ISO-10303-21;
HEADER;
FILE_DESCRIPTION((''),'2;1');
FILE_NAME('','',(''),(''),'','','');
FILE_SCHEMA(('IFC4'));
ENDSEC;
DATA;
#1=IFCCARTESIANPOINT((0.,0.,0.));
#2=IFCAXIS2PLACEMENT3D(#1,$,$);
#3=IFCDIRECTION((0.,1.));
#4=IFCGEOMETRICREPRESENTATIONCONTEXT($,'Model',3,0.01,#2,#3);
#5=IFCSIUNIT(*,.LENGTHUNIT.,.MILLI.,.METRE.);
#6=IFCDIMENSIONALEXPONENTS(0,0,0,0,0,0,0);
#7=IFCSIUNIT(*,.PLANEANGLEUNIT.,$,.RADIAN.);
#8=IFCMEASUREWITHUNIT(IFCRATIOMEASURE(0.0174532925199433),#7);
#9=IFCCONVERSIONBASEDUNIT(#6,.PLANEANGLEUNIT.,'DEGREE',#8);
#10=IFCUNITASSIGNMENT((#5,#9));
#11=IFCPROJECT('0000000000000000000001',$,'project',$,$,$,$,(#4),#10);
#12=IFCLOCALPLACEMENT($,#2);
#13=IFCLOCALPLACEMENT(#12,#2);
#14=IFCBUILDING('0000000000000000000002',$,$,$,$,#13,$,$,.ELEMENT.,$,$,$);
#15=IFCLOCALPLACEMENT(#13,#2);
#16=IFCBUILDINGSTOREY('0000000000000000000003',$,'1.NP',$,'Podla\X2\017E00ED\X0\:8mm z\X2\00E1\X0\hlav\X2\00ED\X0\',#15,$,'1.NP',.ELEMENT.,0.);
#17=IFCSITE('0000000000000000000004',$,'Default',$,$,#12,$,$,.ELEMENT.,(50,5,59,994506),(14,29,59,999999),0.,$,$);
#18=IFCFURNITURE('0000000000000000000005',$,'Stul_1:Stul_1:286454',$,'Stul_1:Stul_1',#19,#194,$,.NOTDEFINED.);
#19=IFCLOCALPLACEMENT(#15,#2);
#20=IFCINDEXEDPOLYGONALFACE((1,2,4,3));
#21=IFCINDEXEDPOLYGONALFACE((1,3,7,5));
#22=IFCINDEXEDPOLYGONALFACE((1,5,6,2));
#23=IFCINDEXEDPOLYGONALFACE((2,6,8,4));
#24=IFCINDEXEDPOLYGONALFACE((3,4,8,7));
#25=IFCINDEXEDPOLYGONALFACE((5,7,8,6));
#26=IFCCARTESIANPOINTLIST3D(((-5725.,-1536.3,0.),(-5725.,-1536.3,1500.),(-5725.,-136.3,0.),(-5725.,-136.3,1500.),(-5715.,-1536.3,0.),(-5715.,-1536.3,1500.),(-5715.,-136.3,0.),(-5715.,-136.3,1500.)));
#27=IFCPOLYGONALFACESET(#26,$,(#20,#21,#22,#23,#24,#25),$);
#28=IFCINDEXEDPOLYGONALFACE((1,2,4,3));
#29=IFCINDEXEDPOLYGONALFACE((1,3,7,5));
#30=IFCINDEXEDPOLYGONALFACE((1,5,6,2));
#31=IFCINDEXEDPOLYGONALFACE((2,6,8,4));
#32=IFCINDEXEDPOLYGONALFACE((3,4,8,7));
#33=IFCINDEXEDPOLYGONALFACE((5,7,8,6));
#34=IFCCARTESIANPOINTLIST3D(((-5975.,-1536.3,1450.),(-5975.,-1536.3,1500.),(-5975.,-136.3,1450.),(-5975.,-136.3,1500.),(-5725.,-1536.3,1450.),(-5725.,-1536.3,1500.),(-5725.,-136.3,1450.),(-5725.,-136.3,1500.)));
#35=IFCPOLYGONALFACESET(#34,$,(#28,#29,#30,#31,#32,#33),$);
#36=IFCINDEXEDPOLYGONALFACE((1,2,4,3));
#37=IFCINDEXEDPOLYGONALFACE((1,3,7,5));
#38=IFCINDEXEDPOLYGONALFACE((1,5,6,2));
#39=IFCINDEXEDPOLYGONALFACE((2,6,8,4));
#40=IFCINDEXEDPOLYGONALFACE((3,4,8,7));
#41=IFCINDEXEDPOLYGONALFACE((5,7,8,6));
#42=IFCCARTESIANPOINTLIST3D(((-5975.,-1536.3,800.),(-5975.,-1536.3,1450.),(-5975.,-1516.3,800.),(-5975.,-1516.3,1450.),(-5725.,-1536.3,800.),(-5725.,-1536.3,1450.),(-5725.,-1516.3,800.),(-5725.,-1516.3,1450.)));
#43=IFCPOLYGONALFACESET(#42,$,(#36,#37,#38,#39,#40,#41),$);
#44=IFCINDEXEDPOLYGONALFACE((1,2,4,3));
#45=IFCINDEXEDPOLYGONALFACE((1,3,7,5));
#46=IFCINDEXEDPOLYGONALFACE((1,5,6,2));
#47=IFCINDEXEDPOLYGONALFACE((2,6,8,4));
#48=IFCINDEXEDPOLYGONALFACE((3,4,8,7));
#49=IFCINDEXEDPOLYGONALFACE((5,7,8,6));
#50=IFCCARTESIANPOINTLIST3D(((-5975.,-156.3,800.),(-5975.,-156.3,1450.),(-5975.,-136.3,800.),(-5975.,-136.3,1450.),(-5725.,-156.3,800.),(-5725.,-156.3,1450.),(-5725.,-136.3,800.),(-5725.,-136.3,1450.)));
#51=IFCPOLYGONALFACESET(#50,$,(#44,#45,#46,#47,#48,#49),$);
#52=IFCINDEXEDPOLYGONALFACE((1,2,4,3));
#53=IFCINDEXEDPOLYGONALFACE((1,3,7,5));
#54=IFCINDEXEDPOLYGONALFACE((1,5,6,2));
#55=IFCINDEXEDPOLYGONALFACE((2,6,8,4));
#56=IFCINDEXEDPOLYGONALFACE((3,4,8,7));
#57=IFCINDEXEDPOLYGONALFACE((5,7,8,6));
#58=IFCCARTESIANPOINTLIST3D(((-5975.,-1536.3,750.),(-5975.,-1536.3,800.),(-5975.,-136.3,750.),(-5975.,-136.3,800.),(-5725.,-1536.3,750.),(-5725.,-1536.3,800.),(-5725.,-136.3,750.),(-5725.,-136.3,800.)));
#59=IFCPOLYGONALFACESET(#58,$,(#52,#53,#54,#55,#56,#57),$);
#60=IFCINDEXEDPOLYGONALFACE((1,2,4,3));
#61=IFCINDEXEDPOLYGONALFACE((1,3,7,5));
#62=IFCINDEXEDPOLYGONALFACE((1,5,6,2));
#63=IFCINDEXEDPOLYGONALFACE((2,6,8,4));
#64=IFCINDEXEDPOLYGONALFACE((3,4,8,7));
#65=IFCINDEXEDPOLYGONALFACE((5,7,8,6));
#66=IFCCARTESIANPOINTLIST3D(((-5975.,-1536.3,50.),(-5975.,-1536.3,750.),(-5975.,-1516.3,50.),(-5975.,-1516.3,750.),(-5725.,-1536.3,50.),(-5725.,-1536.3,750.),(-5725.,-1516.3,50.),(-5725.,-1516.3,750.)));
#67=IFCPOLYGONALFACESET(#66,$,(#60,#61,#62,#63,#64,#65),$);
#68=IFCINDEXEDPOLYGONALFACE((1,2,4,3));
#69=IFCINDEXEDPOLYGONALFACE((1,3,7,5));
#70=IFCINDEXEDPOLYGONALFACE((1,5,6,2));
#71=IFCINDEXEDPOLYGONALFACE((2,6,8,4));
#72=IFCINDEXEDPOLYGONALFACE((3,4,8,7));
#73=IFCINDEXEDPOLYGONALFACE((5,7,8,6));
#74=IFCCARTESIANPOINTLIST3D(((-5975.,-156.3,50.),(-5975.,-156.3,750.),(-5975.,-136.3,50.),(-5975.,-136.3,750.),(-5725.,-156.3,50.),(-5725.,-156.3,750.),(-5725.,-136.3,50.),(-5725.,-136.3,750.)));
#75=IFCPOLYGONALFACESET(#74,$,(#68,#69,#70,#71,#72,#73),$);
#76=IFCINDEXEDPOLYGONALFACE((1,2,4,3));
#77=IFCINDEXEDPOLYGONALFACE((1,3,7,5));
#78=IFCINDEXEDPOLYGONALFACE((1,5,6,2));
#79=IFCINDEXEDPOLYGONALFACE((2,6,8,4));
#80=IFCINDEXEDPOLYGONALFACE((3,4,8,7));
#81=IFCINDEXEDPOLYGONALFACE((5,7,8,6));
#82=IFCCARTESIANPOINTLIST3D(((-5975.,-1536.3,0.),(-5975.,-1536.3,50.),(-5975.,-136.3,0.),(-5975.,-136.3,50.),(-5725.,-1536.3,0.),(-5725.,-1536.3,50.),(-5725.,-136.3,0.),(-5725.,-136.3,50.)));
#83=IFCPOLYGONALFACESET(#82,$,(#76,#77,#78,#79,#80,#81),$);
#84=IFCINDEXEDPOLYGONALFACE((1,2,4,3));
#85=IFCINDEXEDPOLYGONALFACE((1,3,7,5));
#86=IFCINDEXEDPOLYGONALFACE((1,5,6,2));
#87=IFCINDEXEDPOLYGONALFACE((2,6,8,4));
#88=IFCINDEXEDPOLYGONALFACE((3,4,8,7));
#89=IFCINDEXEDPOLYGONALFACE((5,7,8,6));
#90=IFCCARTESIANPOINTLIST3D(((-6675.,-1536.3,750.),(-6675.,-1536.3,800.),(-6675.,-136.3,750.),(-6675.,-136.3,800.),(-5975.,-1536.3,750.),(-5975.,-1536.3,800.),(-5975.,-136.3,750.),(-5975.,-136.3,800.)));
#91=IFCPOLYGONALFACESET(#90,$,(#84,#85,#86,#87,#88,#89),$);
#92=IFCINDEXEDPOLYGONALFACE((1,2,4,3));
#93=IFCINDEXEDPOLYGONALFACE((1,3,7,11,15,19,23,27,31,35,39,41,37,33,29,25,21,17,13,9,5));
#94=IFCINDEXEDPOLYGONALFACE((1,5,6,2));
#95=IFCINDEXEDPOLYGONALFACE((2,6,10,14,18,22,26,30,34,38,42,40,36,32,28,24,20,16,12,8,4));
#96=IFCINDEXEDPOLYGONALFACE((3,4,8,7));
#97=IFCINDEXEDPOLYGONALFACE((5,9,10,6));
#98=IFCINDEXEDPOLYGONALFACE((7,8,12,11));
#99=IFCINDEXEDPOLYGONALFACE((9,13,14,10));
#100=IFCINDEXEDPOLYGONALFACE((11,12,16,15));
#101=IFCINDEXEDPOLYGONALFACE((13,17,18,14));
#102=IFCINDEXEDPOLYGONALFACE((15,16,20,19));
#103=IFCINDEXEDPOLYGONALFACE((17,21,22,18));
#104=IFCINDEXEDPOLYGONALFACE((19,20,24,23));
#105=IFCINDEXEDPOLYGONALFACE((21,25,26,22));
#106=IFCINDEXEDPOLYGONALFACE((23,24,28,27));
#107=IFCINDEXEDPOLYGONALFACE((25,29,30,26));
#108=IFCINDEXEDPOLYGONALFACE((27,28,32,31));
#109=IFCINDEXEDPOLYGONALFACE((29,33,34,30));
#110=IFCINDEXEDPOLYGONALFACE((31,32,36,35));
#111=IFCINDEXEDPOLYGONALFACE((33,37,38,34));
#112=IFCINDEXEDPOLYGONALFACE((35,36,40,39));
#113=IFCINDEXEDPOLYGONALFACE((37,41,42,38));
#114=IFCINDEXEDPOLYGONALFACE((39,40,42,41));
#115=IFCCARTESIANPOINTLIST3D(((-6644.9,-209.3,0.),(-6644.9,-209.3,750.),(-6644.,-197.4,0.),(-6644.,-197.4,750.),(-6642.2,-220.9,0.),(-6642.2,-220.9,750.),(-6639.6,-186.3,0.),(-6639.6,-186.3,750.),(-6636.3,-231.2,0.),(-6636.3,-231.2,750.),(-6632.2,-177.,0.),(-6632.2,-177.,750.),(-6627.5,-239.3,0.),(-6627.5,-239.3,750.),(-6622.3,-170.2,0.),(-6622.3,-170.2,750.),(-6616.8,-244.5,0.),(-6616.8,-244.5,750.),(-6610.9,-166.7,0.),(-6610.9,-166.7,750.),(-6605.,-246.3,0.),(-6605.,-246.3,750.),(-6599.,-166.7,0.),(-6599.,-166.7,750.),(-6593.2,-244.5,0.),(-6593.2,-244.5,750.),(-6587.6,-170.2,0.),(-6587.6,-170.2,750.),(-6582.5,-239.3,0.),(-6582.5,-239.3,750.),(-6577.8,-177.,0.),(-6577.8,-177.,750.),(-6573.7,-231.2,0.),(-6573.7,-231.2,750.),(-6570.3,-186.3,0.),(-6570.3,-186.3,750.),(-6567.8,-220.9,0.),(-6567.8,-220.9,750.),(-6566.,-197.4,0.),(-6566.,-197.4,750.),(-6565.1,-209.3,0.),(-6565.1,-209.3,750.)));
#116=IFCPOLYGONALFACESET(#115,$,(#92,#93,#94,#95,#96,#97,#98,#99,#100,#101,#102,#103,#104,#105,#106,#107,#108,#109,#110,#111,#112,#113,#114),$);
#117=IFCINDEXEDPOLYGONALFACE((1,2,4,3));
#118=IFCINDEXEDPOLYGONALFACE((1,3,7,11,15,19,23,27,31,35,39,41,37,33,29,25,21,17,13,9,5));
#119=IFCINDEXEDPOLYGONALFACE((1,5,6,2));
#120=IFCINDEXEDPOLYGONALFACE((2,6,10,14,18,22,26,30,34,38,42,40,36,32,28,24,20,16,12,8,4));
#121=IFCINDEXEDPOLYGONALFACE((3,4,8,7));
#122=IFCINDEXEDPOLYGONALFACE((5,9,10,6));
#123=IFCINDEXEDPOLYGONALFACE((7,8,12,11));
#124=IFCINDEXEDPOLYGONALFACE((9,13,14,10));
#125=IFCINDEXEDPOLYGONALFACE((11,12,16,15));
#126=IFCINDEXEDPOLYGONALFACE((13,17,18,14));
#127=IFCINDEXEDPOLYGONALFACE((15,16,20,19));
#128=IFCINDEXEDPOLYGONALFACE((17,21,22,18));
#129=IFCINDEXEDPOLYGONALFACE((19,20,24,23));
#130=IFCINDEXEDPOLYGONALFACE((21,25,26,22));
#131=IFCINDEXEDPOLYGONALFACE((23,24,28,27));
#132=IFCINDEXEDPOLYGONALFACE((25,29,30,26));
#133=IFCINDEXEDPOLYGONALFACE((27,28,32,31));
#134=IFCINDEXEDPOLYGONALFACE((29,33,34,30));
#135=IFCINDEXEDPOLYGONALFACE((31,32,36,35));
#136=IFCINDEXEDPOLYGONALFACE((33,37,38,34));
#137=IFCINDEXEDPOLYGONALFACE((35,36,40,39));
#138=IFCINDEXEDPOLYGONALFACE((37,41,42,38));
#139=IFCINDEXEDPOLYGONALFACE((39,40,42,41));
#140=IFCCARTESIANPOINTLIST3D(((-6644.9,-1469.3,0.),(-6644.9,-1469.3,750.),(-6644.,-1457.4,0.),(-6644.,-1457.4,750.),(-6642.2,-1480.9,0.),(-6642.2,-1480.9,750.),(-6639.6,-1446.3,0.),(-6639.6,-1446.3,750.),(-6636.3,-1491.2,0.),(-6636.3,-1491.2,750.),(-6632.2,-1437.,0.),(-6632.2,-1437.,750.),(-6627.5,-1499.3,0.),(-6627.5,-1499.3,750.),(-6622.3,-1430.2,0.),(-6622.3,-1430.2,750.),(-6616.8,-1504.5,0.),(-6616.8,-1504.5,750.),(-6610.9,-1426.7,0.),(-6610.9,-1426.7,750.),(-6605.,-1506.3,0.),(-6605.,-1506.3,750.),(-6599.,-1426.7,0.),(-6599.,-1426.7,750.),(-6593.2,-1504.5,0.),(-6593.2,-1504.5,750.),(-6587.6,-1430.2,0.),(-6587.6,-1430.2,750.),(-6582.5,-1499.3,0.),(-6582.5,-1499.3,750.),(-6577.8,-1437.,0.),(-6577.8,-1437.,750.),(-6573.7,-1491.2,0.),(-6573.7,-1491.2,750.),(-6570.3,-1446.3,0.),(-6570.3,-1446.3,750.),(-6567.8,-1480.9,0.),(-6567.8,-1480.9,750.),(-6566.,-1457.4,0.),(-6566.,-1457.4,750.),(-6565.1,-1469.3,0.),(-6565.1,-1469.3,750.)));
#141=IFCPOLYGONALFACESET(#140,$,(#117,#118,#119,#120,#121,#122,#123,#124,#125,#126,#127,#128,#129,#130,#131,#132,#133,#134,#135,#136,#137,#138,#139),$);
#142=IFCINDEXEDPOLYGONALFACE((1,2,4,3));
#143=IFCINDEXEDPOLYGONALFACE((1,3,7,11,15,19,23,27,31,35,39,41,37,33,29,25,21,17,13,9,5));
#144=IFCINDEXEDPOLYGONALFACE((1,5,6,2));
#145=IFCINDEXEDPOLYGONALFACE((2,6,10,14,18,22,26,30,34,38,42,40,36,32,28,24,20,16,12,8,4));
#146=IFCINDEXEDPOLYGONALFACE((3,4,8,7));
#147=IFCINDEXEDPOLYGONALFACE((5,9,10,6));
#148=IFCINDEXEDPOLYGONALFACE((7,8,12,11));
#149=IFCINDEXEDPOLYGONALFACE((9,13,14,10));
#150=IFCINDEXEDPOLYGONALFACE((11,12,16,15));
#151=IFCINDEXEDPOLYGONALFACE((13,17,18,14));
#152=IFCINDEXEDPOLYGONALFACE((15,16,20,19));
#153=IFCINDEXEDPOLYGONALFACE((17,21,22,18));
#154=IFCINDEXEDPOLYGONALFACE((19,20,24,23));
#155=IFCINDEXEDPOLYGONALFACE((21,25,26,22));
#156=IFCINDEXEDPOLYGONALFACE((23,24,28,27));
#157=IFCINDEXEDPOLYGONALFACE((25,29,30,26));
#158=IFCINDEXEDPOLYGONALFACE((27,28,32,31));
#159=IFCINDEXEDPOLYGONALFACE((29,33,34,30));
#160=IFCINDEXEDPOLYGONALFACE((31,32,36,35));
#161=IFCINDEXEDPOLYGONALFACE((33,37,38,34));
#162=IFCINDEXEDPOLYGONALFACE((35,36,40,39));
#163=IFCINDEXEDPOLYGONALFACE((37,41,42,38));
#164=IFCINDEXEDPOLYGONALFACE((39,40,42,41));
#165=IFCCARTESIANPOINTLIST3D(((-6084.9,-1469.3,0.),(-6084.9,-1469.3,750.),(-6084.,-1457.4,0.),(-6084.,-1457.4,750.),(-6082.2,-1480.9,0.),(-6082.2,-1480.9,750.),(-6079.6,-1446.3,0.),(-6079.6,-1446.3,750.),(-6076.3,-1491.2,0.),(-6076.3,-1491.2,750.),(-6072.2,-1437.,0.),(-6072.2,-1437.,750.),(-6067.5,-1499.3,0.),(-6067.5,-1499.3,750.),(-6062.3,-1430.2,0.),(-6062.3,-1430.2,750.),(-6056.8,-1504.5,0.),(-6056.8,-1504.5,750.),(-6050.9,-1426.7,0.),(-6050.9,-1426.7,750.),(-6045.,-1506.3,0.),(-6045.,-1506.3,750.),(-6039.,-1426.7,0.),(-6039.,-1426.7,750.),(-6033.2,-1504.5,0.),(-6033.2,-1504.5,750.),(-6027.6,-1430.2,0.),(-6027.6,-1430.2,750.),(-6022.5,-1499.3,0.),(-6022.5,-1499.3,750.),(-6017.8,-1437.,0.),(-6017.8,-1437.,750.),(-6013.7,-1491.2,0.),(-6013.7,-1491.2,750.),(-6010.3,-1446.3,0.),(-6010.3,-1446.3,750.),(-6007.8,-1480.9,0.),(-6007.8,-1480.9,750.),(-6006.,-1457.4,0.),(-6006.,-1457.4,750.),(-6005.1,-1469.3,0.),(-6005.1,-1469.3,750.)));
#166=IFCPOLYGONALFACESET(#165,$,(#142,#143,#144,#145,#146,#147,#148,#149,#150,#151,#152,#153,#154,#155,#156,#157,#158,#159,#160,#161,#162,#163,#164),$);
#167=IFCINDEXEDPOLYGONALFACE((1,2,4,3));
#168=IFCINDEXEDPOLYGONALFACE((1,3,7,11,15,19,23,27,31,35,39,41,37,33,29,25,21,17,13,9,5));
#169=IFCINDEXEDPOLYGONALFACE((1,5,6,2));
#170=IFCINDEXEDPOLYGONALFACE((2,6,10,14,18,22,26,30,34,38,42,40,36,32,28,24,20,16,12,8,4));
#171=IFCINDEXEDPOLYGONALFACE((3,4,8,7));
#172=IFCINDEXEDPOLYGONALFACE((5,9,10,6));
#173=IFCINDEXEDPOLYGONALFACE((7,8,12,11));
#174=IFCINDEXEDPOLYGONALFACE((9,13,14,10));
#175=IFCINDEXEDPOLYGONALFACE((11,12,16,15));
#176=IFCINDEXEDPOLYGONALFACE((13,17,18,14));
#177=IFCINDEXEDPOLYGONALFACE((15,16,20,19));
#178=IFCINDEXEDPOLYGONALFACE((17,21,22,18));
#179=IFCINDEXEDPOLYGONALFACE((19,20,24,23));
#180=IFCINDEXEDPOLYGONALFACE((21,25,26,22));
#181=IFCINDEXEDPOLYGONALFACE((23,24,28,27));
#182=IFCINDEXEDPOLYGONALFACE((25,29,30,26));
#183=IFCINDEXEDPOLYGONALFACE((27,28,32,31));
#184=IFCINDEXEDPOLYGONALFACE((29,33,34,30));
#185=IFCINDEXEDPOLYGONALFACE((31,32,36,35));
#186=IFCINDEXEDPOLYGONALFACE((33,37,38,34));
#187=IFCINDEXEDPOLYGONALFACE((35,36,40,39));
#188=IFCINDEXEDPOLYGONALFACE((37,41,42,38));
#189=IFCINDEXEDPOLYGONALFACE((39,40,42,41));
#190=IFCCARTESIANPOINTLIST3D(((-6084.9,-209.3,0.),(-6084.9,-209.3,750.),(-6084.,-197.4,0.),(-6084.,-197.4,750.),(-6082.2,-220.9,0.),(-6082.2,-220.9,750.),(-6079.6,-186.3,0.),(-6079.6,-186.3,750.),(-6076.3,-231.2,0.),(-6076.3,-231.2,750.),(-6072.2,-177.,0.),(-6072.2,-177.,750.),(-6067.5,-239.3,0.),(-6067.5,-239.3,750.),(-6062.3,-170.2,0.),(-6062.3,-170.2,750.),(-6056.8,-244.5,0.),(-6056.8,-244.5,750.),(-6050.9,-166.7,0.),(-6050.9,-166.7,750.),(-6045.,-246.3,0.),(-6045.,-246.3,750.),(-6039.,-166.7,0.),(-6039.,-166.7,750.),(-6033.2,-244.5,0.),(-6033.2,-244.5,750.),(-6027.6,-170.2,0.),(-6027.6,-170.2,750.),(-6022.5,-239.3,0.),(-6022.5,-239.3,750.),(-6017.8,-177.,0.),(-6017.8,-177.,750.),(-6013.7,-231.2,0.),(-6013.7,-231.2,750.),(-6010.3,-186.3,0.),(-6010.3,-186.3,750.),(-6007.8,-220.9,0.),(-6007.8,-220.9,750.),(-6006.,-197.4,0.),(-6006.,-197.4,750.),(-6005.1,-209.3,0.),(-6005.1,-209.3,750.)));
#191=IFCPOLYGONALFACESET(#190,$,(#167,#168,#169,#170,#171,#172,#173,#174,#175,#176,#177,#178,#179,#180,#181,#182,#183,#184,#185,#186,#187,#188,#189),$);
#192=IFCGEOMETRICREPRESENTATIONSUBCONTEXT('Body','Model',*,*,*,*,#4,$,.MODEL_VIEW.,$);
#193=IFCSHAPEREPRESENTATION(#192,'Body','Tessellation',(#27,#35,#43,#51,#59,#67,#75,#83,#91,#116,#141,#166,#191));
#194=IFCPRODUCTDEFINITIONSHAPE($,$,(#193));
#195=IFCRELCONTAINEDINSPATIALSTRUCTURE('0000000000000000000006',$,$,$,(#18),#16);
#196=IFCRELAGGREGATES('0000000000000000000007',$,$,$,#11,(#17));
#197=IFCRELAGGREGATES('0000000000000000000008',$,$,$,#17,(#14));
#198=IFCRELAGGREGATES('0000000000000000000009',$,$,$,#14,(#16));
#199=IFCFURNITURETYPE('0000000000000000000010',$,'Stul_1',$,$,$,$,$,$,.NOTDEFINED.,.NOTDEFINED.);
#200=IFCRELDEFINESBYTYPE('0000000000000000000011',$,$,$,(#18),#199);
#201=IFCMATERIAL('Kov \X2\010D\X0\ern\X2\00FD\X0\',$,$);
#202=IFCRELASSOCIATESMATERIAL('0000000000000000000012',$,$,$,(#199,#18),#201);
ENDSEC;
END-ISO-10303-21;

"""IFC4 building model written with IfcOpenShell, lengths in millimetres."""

from ifc_helpers import new_model, entity, si_unit, converted_unit, direction, frame, frame_2d, origin, origin_2d_with_axis, place, context, subcontext, project, spatial, rectangle, circle, extrude, source, transform, mapped, material, type_object, type_shapes, element, save


model = new_model("IFC4")

# Units and contexts
model_context = context("Model", 3, precision=0.01, world=origin(), true_north=direction((0.0, 1.0)))
body_context = subcontext(model_context, "Body", "Model", "MODEL_VIEW")
ifc_project = project(units=[si_unit("LENGTHUNIT", "METRE", prefix="MILLI"), converted_unit("PLANEANGLEUNIT", "DEGREE", entity("IfcRatioMeasure", 0.0174532925199433), si_unit("PLANEANGLEUNIT", "RADIAN"), dimensions=[0, 0, 0, 0, 0, 0, 0])], contexts=[model_context])

# Site, building, storey
site_placement = place(None, origin())
site = spatial("IfcSite", under=ifc_project, at=site_placement, Name="Default", CompositionType="ELEMENT", RefLatitude=(50, 5, 59, 994506), RefLongitude=(14, 29, 59, 999999), RefElevation=0.0)
building_placement = place(site_placement, origin())
building = spatial("IfcBuilding", under=site, at=building_placement, CompositionType="ELEMENT")
storey_placement = place(building_placement, origin())
storey = spatial("IfcBuildingStorey", under=building, at=storey_placement, Name="1.NP", ObjectType="Podlaží:8mm záhlaví", LongName="1.NP", CompositionType="ELEMENT", Elevation=0.0)

# Furniture
ifc_material_1 = material(Name="Kov černý")
furniture_type = type_object("IfcFurnitureType", Name="Stul_1", AssemblyPlace="NOTDEFINED", PredefinedType="NOTDEFINED", material=ifc_material_1)
shared_shape_1 = source(origin(), body_context, "Body", "SweptSolid", [
    extrude(rectangle(XDim=1400.0, YDim=10.0, at=origin_2d_with_axis()), frame((0.0, 605.0, 0.0), z_axis=(0.0, 0.0, 1.0), x_axis=(-1.0, 0.0, 0.0)), (0.0, 0.0, 1.0), 1500.0),
    extrude(rectangle(XDim=1400.0, YDim=250.0, at=frame_2d((0.0, 0.0), x_axis=(1.0, 0.0))), frame((0.0, 475.0, 1450.0), z_axis=(0.0, 0.0, 1.0), x_axis=(-1.0, 0.0, 0.0)), (0.0, 0.0, 1.0), 50.0),
    extrude(rectangle(XDim=20.0, YDim=250.0, at=origin_2d_with_axis()), frame((690.0, 475.0, 800.0), z_axis=(0.0, 0.0, 1.0), x_axis=(-1.0, 0.0, 0.0)), (0.0, 0.0, 1.0), 650.0),
    extrude(rectangle(XDim=20.0, YDim=250.0, at=frame_2d((0.0, 0.0), x_axis=(1.0, 0.0))), frame((-690.0, 475.0, 800.0), z_axis=(0.0, 0.0, 1.0), x_axis=(-1.0, 0.0, 0.0)), (0.0, 0.0, 1.0), 650.0),
    extrude(rectangle(XDim=1400.0, YDim=250.0, at=origin_2d_with_axis()), frame((0.0, 475.0, 750.0), z_axis=(0.0, 0.0, 1.0), x_axis=(-1.0, 0.0, 0.0)), (0.0, 0.0, 1.0), 50.0),
    extrude(rectangle(XDim=20.0, YDim=250.0, at=origin_2d_with_axis()), frame((690.0, 475.0, 50.0), z_axis=(0.0, 0.0, 1.0), x_axis=(-1.0, 0.0, 0.0)), (0.0, 0.0, 1.0), 700.0),
    extrude(rectangle(XDim=20.0, YDim=250.0, at=frame_2d((0.0, 0.0), x_axis=(1.0, 0.0))), frame((-690.0, 475.0, 50.0), z_axis=(0.0, 0.0, 1.0), x_axis=(-1.0, 0.0, 0.0)), (0.0, 0.0, 1.0), 700.0),
    extrude(rectangle(XDim=1400.0, YDim=250.0, at=origin_2d_with_axis()), frame((0.0, 475.0, 0.0), z_axis=(0.0, 0.0, 1.0), x_axis=(-1.0, 0.0, 0.0)), (0.0, 0.0, 1.0), 50.0),
    extrude(rectangle(XDim=1400.0, YDim=700.0, at=origin_2d_with_axis()), frame((0.0, 0.0, 750.0), z_axis=(0.0, 0.0, 1.0), x_axis=(-1.0, 0.0, 0.0)), (0.0, 0.0, 1.0), 50.0),
    extrude(circle(Radius=40.0, at=frame_2d((0.0, 0.0), x_axis=(1.0, 0.0))), frame((-630.0, -280.0, 0.0)), (0.0, 0.0, 1.0), 750.0),
    extrude(circle(Radius=40.0, at=frame_2d((0.0, 0.0), x_axis=(1.0, 0.0))), frame((630.0, -280.0, 0.0)), (0.0, 0.0, 1.0), 750.0),
    extrude(circle(Radius=40.0, at=frame_2d((0.0, 0.0), x_axis=(1.0, 0.0))), frame((630.0, 280.0, 0.0)), (0.0, 0.0, 1.0), 750.0),
    extrude(circle(Radius=40.0, at=frame_2d((0.0, 0.0), x_axis=(1.0, 0.0))), frame((-630.0, 280.0, 0.0)), (0.0, 0.0, 1.0), 750.0),
])
type_shapes(furniture_type, [shared_shape_1])
for number, where, z_axis, x_axis, name in (
    (1, (-6325.0, -836.3, 0.0), (0.0, 0.0, 1.0), (0.0, -1.0, 0.0), "Stul_1:Stul_1:286454"),
):
    element("IfcFurniture", number, at=place(storey_placement, frame(where, z_axis=z_axis, x_axis=x_axis)), inside=storey, type_object=furniture_type, material=ifc_material_1, Name=name, ObjectType="Stul_1:Stul_1", PredefinedType="NOTDEFINED", context=body_context, shape_type="MappedRepresentation", body=[
        mapped(shared_shape_1, transform((0.0, 0.0, 0.0), scale=1.0)),
    ])

save(model, "model.ifc")
